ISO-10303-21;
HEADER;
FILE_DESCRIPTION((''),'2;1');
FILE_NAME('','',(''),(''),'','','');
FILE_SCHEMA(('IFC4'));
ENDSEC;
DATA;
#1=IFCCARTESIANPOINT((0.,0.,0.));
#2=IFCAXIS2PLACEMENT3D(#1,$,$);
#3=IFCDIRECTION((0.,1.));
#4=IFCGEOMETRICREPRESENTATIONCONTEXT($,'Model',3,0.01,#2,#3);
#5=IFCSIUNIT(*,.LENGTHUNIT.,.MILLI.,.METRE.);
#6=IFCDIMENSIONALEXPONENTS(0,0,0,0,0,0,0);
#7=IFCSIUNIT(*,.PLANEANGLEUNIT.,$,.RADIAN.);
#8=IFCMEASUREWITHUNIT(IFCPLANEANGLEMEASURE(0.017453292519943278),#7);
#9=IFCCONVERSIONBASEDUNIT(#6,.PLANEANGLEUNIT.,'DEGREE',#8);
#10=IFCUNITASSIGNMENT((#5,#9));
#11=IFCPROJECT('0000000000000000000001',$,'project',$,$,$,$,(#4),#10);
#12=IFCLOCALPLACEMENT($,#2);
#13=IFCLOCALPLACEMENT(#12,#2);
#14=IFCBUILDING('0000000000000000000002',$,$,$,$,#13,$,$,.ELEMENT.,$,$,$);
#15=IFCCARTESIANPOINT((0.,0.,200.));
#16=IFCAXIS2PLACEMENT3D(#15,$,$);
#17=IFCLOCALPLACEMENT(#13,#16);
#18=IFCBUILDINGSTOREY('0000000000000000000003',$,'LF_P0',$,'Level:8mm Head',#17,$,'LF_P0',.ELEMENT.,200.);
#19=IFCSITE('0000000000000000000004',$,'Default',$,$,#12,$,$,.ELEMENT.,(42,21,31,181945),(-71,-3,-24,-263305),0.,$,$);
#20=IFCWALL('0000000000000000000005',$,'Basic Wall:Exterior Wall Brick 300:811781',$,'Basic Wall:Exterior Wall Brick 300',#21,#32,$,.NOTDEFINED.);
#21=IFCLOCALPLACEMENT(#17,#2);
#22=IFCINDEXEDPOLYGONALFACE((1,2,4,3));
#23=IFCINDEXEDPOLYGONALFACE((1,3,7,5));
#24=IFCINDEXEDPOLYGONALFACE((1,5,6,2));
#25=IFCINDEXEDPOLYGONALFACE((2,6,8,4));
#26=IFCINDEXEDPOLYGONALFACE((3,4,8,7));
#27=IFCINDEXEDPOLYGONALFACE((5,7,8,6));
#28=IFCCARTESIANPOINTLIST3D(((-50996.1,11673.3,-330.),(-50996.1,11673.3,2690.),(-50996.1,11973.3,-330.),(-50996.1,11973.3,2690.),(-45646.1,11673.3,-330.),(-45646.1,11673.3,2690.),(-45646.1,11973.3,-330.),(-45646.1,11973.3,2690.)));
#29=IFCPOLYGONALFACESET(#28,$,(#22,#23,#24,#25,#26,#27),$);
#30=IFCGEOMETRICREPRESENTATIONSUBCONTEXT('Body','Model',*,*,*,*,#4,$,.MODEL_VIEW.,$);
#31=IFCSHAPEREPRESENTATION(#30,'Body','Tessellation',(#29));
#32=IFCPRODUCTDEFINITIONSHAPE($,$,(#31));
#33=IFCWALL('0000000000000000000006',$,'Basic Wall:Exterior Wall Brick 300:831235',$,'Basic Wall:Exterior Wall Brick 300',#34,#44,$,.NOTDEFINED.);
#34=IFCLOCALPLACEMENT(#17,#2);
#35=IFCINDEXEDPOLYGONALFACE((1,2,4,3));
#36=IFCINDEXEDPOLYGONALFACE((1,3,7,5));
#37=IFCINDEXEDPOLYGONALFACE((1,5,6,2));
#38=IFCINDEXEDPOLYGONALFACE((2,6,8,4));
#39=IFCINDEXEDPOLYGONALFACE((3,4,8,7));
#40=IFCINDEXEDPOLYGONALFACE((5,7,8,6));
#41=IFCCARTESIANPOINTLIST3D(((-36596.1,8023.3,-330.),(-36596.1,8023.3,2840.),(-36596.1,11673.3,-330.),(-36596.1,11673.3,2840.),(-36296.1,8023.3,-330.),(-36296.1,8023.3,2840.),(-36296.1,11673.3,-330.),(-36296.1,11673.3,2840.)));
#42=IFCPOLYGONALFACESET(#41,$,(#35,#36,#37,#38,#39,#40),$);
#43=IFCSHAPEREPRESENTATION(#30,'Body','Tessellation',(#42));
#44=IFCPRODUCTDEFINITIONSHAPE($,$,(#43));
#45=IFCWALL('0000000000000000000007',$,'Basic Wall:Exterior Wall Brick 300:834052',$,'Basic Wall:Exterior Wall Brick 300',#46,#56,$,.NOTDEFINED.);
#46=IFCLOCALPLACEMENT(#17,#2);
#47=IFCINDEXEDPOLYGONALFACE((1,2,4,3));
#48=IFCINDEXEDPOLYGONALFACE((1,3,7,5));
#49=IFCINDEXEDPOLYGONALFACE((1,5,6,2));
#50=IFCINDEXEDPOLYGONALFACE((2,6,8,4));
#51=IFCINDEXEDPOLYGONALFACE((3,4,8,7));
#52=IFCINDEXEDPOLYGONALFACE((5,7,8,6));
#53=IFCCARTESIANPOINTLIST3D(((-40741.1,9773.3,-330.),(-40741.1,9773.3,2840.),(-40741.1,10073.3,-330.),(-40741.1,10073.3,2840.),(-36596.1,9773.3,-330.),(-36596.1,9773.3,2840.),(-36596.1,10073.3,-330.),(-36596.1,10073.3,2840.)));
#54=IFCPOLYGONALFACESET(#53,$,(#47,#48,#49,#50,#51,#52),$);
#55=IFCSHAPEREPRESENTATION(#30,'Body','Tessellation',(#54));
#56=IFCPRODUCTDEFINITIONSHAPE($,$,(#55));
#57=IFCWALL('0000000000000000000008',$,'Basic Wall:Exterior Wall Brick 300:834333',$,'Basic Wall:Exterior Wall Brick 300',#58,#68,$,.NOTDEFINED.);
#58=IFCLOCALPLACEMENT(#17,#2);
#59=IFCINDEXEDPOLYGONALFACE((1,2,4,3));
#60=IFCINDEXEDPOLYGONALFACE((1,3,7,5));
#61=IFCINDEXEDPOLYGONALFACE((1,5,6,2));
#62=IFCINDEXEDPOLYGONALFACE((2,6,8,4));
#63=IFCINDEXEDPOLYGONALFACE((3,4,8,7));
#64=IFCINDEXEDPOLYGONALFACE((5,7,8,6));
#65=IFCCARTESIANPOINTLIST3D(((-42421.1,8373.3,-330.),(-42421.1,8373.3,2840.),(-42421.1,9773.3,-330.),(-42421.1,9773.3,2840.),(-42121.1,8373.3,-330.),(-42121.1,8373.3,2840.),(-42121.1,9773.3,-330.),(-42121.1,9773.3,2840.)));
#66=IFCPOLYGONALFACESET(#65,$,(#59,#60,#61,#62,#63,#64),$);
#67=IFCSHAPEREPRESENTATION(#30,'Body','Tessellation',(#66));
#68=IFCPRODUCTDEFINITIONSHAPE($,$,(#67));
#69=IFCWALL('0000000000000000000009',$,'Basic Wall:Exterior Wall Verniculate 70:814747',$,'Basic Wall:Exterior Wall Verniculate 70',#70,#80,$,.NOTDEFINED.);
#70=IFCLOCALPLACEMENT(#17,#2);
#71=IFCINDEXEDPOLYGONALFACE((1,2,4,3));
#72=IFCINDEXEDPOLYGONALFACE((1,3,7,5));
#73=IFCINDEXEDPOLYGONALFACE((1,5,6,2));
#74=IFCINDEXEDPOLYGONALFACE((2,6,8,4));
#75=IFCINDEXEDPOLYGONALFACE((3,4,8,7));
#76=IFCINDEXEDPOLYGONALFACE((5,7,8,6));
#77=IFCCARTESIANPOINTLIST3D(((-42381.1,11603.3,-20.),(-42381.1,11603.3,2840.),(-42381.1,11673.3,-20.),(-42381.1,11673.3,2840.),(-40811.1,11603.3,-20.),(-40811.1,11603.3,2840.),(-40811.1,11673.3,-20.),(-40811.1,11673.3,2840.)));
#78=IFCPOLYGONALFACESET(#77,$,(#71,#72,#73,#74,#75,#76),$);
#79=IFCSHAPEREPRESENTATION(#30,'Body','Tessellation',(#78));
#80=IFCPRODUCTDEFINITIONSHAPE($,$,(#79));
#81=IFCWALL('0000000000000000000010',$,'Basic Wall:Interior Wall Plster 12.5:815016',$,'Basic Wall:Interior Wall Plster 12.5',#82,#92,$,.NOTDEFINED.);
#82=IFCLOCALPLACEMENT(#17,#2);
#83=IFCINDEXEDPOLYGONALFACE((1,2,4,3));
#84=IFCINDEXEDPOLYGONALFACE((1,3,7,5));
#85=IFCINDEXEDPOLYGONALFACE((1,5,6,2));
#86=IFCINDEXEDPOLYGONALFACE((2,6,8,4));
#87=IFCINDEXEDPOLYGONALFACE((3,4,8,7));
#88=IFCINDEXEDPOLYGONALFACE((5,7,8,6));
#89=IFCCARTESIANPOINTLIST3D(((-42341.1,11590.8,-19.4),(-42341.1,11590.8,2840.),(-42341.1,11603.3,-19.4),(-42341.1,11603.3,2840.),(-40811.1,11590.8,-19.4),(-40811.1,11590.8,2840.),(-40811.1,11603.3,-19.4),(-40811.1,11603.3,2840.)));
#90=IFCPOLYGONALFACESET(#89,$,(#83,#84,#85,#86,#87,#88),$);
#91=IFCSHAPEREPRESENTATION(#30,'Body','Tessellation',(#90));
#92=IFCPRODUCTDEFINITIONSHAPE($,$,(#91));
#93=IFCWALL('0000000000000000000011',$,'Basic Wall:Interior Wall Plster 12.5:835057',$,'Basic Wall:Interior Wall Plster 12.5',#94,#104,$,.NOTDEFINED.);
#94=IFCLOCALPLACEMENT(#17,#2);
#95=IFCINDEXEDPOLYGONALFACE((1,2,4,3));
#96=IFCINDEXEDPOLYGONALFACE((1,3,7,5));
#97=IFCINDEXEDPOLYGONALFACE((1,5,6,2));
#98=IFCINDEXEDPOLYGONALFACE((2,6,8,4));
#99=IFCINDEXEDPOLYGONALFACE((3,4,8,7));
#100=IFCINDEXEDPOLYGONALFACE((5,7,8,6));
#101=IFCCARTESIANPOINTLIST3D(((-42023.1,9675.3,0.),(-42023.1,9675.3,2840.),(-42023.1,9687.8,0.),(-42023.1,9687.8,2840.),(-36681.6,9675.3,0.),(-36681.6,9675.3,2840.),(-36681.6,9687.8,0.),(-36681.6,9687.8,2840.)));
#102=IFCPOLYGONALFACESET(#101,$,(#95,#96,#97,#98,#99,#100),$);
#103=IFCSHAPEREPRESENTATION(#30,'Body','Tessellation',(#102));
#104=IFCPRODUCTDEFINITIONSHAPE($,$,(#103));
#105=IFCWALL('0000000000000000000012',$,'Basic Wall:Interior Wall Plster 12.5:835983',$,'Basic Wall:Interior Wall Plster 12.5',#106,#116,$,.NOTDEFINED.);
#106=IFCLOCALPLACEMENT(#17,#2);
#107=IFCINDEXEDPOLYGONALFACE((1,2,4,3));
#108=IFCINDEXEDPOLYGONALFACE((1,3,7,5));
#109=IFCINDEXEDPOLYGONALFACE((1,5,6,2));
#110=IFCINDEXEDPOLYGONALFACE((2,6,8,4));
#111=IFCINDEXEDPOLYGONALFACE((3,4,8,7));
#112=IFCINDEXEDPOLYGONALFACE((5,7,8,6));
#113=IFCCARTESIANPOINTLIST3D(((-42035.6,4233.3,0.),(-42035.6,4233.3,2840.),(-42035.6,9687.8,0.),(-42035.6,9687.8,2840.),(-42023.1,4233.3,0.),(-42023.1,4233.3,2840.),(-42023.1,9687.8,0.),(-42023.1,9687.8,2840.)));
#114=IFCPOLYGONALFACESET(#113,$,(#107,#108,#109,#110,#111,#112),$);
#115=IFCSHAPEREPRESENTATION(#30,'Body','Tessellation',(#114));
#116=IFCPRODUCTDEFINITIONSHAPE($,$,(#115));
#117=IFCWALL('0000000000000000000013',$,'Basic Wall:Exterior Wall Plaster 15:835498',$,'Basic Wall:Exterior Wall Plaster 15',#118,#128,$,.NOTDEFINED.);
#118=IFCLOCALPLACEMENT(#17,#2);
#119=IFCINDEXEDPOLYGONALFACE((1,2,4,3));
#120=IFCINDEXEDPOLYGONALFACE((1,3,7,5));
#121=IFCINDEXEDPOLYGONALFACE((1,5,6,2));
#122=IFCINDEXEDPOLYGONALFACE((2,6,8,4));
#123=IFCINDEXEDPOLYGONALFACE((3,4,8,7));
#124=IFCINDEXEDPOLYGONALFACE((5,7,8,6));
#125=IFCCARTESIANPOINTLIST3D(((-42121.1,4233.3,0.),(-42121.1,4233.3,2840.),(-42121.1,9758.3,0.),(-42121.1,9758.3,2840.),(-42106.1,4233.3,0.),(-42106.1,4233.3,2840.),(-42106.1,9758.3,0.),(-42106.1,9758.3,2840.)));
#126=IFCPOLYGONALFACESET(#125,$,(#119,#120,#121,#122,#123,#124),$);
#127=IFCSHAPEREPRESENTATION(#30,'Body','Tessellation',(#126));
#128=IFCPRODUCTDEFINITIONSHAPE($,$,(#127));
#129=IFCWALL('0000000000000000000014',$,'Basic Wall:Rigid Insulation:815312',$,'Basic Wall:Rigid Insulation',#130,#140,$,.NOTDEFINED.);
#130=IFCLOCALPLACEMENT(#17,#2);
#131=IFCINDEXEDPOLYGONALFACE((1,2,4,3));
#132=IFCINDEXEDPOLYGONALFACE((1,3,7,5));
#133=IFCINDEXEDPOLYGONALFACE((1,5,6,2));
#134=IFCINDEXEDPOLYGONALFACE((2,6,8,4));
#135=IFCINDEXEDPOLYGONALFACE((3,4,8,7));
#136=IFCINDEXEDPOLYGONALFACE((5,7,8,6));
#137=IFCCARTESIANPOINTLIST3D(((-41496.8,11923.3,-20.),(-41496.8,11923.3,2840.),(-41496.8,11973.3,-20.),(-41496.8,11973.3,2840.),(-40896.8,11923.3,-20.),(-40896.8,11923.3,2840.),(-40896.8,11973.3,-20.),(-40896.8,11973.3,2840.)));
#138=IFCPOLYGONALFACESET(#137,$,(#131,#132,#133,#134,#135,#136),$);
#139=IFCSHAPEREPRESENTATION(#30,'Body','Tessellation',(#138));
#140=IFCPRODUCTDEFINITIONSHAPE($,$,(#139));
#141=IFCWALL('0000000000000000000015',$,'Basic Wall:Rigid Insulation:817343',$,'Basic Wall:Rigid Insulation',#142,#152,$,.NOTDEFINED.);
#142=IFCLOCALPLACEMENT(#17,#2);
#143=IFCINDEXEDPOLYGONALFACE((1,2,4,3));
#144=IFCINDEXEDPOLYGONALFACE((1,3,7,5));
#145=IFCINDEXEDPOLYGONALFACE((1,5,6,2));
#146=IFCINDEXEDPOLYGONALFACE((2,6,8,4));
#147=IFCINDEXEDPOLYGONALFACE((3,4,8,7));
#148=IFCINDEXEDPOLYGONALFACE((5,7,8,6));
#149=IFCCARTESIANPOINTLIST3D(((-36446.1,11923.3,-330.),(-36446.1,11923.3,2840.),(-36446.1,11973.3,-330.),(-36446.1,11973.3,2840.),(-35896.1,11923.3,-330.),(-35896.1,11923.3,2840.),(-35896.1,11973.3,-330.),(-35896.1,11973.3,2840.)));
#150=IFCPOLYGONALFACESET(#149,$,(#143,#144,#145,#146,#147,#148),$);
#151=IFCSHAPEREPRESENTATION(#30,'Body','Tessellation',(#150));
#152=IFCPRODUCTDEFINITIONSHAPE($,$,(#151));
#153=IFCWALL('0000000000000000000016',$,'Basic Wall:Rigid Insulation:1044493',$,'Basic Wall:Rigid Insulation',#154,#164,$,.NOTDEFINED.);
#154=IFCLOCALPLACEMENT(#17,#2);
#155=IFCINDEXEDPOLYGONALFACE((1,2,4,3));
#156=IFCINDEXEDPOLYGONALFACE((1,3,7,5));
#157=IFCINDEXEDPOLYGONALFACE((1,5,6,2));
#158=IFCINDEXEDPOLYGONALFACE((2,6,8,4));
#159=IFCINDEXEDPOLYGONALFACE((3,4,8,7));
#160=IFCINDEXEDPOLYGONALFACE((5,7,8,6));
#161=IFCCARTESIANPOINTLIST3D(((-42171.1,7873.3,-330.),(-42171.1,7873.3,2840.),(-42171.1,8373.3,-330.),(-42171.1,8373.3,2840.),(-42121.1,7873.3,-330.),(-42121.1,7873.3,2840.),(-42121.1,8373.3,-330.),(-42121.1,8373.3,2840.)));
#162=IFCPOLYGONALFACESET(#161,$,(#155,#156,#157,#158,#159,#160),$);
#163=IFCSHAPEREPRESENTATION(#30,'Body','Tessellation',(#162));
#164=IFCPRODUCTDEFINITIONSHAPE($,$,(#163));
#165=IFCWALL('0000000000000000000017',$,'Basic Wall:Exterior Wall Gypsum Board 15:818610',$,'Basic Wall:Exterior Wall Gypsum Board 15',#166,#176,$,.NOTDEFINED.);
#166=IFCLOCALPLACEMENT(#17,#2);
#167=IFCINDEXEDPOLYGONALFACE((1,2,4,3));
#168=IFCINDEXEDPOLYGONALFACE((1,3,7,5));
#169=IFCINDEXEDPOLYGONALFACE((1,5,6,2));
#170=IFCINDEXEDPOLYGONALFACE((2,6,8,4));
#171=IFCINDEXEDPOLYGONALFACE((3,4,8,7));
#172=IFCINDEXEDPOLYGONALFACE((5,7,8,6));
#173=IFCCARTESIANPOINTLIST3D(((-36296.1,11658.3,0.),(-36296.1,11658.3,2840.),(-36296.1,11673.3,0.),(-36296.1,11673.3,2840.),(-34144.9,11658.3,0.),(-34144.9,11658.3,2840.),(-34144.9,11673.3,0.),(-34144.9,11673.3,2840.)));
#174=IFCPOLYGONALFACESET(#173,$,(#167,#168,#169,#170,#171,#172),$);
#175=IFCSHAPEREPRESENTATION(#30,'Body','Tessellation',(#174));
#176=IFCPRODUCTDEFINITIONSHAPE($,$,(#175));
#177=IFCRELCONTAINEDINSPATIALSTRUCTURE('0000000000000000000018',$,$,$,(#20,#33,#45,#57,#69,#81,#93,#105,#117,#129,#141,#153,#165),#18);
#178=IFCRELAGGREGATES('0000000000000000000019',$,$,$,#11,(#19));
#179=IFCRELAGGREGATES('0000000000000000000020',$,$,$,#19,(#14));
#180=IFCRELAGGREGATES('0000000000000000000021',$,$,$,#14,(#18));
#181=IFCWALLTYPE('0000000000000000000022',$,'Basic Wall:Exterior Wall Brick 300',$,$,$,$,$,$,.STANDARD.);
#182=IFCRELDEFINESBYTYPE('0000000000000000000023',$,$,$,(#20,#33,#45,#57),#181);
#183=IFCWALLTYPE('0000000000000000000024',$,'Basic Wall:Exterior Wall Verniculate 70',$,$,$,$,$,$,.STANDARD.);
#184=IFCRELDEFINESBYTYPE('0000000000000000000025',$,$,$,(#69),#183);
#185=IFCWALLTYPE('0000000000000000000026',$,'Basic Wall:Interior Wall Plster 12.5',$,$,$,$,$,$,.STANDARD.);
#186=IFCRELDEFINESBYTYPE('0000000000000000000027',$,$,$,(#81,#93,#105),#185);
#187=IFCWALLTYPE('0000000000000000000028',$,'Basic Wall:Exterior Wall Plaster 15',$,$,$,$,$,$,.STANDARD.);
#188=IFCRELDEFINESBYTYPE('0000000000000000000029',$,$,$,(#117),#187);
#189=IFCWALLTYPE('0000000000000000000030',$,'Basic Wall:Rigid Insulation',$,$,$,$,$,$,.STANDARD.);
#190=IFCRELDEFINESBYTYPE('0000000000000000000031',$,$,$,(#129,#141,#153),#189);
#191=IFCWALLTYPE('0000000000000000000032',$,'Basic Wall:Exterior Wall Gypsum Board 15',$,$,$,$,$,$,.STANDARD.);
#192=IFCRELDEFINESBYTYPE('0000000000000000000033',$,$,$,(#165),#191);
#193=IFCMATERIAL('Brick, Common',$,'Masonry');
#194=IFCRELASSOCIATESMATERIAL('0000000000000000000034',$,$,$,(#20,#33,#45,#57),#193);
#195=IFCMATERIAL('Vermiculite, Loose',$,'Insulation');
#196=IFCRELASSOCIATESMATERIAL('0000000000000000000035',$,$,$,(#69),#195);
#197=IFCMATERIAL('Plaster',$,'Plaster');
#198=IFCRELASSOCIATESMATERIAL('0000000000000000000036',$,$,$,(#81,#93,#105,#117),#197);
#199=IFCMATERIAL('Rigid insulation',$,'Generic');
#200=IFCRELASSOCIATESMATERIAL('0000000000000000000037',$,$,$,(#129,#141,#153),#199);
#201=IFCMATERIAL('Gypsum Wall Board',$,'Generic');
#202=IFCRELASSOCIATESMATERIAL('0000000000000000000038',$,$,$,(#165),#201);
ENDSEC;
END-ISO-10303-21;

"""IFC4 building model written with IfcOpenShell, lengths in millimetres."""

from ifc_helpers import new_model, entity, si_unit, converted_unit, direction, frame, origin, place, context, subcontext, project, spatial, indexed_curve, outline, extrude, material, type_object, element, save


model = new_model("IFC4")

# Units and contexts
model_context = context("Model", 3, precision=0.01, world=origin(), true_north=direction((0.0, 1.0)))
body_context = subcontext(model_context, "Body", "Model", "MODEL_VIEW")
ifc_project = project(units=[si_unit("LENGTHUNIT", "METRE", prefix="MILLI"), converted_unit("PLANEANGLEUNIT", "DEGREE", entity("IfcPlaneAngleMeasure", 0.017453292519943278), si_unit("PLANEANGLEUNIT", "RADIAN"), dimensions=[0, 0, 0, 0, 0, 0, 0])], contexts=[model_context])

# Site, building, storey
site_placement = place(None, origin())
site = spatial("IfcSite", under=ifc_project, at=site_placement, Name="Default", CompositionType="ELEMENT", RefLatitude=(42, 21, 31, 181945), RefLongitude=(-71, -3, -24, -263305), RefElevation=0.0)
building_placement = place(site_placement, origin())
building = spatial("IfcBuilding", under=site, at=building_placement, CompositionType="ELEMENT")
storey_placement = place(building_placement, frame((0.0, 0.0, 200.0)))
storey = spatial("IfcBuildingStorey", under=building, at=storey_placement, Name="LF_P0", ObjectType="Level:8mm Head", LongName="LF_P0", CompositionType="ELEMENT", Elevation=200.0)

# Walls
ifc_material_1 = material(Name="Brick, Common", Category="Masonry")
wall_type_1 = type_object("IfcWallType", Name="Basic Wall:Exterior Wall Brick 300", PredefinedType="STANDARD")
wall_1_placement = place(storey_placement, frame((-45646.1, 11823.3, -330.0), z_axis=(0.0, 0.0, 1.0), x_axis=(-1.0, 0.0, 0.0)))
element("IfcWall", 1, at=wall_1_placement, inside=storey, type_object=wall_type_1, material=ifc_material_1, Name="Basic Wall:Exterior Wall Brick 300:811781", ObjectType="Basic Wall:Exterior Wall Brick 300", PredefinedType="NOTDEFINED", context=body_context, shape_type="SweptSolid", body=[
    extrude(outline(indexed_curve([(5350.0, 150.0), (0.0, 150.0), (0.0, -150.0), (5350.0, -150.0), (5350.0, 150.0)], self_intersect=False)), origin(), (0.0, 0.0, 1.0), 3020.0),
])
wall_2_placement = place(storey_placement, frame((-36446.1, 8023.3, -330.0), z_axis=(0.0, 0.0, 1.0), x_axis=(0.0, 1.0, 0.0)))
element("IfcWall", 2, at=wall_2_placement, inside=storey, type_object=wall_type_1, material=ifc_material_1, Name="Basic Wall:Exterior Wall Brick 300:831235", ObjectType="Basic Wall:Exterior Wall Brick 300", PredefinedType="NOTDEFINED", context=body_context, shape_type="SweptSolid", body=[
    extrude(outline(indexed_curve([(3650.0, 150.0), (0.0, 150.0), (0.0, -150.0), (3650.0, -150.0), (3650.0, 150.0)], self_intersect=False)), origin(), (0.0, 0.0, 1.0), 3170.0),
])
wall_3_placement = place(storey_placement, frame((-36596.1, 9923.3, -330.0), z_axis=(0.0, 0.0, 1.0), x_axis=(-1.0, 0.0, 0.0)))
element("IfcWall", 3, at=wall_3_placement, inside=storey, type_object=wall_type_1, material=ifc_material_1, Name="Basic Wall:Exterior Wall Brick 300:834052", ObjectType="Basic Wall:Exterior Wall Brick 300", PredefinedType="NOTDEFINED", context=body_context, shape_type="SweptSolid", body=[
    extrude(outline(indexed_curve([(4145.0, 150.0), (0.0, 150.0), (0.0, -150.0), (4145.0, -150.0), (4145.0, 150.0)], self_intersect=False)), origin(), (0.0, 0.0, 1.0), 3170.0),
])
wall_4_placement = place(storey_placement, frame((-42271.1, 9773.3, -330.0), z_axis=(0.0, 0.0, 1.0), x_axis=(0.0, -1.0, 0.0)))
element("IfcWall", 4, at=wall_4_placement, inside=storey, type_object=wall_type_1, material=ifc_material_1, Name="Basic Wall:Exterior Wall Brick 300:834333", ObjectType="Basic Wall:Exterior Wall Brick 300", PredefinedType="NOTDEFINED", context=body_context, shape_type="SweptSolid", body=[
    extrude(outline(indexed_curve([(1400.0, 150.0), (0.0, 150.0), (0.0, -150.0), (1400.0, -150.0), (1400.0, 150.0)], self_intersect=False)), origin(), (0.0, 0.0, 1.0), 3170.0),
])
ifc_material_2 = material(Name="Vermiculite, Loose", Category="Insulation")
wall_type_2 = type_object("IfcWallType", Name="Basic Wall:Exterior Wall Verniculate 70", PredefinedType="STANDARD")
wall_5_placement = place(storey_placement, frame((-42381.1, 11638.3, -20.0)))
element("IfcWall", 5, at=wall_5_placement, inside=storey, type_object=wall_type_2, material=ifc_material_2, Name="Basic Wall:Exterior Wall Verniculate 70:814747", ObjectType="Basic Wall:Exterior Wall Verniculate 70", PredefinedType="NOTDEFINED", context=body_context, shape_type="SweptSolid", body=[
    extrude(outline(indexed_curve([(1570.0, 35.0), (0.0, 35.0), (0.0, -35.0), (1570.0, -35.0), (1570.0, 35.0)], self_intersect=False)), origin(), (0.0, 0.0, 1.0), 2860.0),
])
ifc_material_3 = material(Name="Plaster", Category="Plaster")
wall_type_3 = type_object("IfcWallType", Name="Basic Wall:Interior Wall Plster 12.5", PredefinedType="STANDARD")
wall_6_placement = place(storey_placement, frame((-42341.1, 11597.1, -19.4)))
element("IfcWall", 6, at=wall_6_placement, inside=storey, type_object=wall_type_3, material=ifc_material_3, Name="Basic Wall:Interior Wall Plster 12.5:815016", ObjectType="Basic Wall:Interior Wall Plster 12.5", PredefinedType="NOTDEFINED", context=body_context, shape_type="SweptSolid", body=[
    extrude(outline(indexed_curve([(1530.0, 6.3), (0.0, 6.3), (0.0, -6.3), (1530.0, -6.3), (1530.0, 6.3)], self_intersect=False)), origin(), (0.0, 0.0, 1.0), 2859.4),
])
wall_7_placement = place(storey_placement, frame((-36681.6, 9681.6, 0.0), z_axis=(0.0, 0.0, 1.0), x_axis=(-1.0, 0.0, 0.0)))
element("IfcWall", 7, at=wall_7_placement, inside=storey, type_object=wall_type_3, material=ifc_material_3, Name="Basic Wall:Interior Wall Plster 12.5:835057", ObjectType="Basic Wall:Interior Wall Plster 12.5", PredefinedType="NOTDEFINED", context=body_context, shape_type="SweptSolid", body=[
    extrude(outline(indexed_curve([(5341.5, 6.2), (0.0, 6.2), (0.0, -6.2), (5341.5, -6.2), (5341.5, 6.2)], self_intersect=False)), origin(), (0.0, 0.0, 1.0), 2840.0),
])
wall_8_placement = place(storey_placement, frame((-42029.4, 9687.8, 0.0), z_axis=(0.0, 0.0, 1.0), x_axis=(0.0, -1.0, 0.0)))
element("IfcWall", 8, at=wall_8_placement, inside=storey, type_object=wall_type_3, material=ifc_material_3, Name="Basic Wall:Interior Wall Plster 12.5:835983", ObjectType="Basic Wall:Interior Wall Plster 12.5", PredefinedType="NOTDEFINED", context=body_context, shape_type="SweptSolid", body=[
    extrude(outline(indexed_curve([(5454.5, 6.3), (0.0, 6.3), (0.0, -6.3), (5454.5, -6.3), (5454.5, 6.3)], self_intersect=False)), origin(), (0.0, 0.0, 1.0), 2840.0),
])
wall_type_4 = type_object("IfcWallType", Name="Basic Wall:Exterior Wall Plaster 15", PredefinedType="STANDARD")
wall_9_placement = place(storey_placement, frame((-42113.6, 9758.3, 0.0), z_axis=(0.0, 0.0, 1.0), x_axis=(0.0, -1.0, 0.0)))
element("IfcWall", 9, at=wall_9_placement, inside=storey, type_object=wall_type_4, material=ifc_material_3, Name="Basic Wall:Exterior Wall Plaster 15:835498", ObjectType="Basic Wall:Exterior Wall Plaster 15", PredefinedType="NOTDEFINED", context=body_context, shape_type="SweptSolid", body=[
    extrude(outline(indexed_curve([(5525.0, 7.5), (0.0, 7.5), (0.0, -7.5), (5525.0, -7.5), (5525.0, 7.5)], self_intersect=False)), origin(), (0.0, 0.0, 1.0), 2840.0),
])
ifc_material_4 = material(Name="Rigid insulation", Category="Generic")
wall_type_5 = type_object("IfcWallType", Name="Basic Wall:Rigid Insulation", PredefinedType="STANDARD")
wall_10_placement = place(storey_placement, frame((-41496.8, 11948.3, -20.0)))
element("IfcWall", 10, at=wall_10_placement, inside=storey, type_object=wall_type_5, material=ifc_material_4, Name="Basic Wall:Rigid Insulation:815312", ObjectType="Basic Wall:Rigid Insulation", PredefinedType="NOTDEFINED", context=body_context, shape_type="SweptSolid", body=[
    extrude(outline(indexed_curve([(600.0, 25.0), (0.0, 25.0), (0.0, -25.0), (600.0, -25.0), (600.0, 25.0)], self_intersect=False)), origin(), (0.0, 0.0, 1.0), 2860.0),
])
wall_11_placement = place(storey_placement, frame((-36446.1, 11948.3, -330.0)))
element("IfcWall", 11, at=wall_11_placement, inside=storey, type_object=wall_type_5, material=ifc_material_4, Name="Basic Wall:Rigid Insulation:817343", ObjectType="Basic Wall:Rigid Insulation", PredefinedType="NOTDEFINED", context=body_context, shape_type="SweptSolid", body=[
    extrude(outline(indexed_curve([(550.0, 25.0), (0.0, 25.0), (0.0, -25.0), (550.0, -25.0), (550.0, 25.0)], self_intersect=False)), origin(), (0.0, 0.0, 1.0), 3170.0),
])
wall_12_placement = place(storey_placement, frame((-42146.1, 8373.3, -330.0), z_axis=(0.0, 0.0, 1.0), x_axis=(0.0, -1.0, 0.0)))
element("IfcWall", 12, at=wall_12_placement, inside=storey, type_object=wall_type_5, material=ifc_material_4, Name="Basic Wall:Rigid Insulation:1044493", ObjectType="Basic Wall:Rigid Insulation", PredefinedType="NOTDEFINED", context=body_context, shape_type="SweptSolid", body=[
    extrude(outline(indexed_curve([(500.0, 25.0), (0.0, 25.0), (0.0, -25.0), (500.0, -25.0), (500.0, 25.0)], self_intersect=False)), origin(), (0.0, 0.0, 1.0), 3170.0),
])
ifc_material_5 = material(Name="Gypsum Wall Board", Category="Generic")
wall_type_6 = type_object("IfcWallType", Name="Basic Wall:Exterior Wall Gypsum Board 15", PredefinedType="STANDARD")
wall_13_placement = place(storey_placement, frame((-36296.1, 11665.8, 0.0)))
element("IfcWall", 13, at=wall_13_placement, inside=storey, type_object=wall_type_6, material=ifc_material_5, Name="Basic Wall:Exterior Wall Gypsum Board 15:818610", ObjectType="Basic Wall:Exterior Wall Gypsum Board 15", PredefinedType="NOTDEFINED", context=body_context, shape_type="SweptSolid", body=[
    extrude(outline(indexed_curve([(2151.2, 7.5), (0.0, 7.5), (0.0, -7.5), (2151.2, -7.5), (2151.2, 7.5)], self_intersect=False)), origin(), (0.0, 0.0, 1.0), 2840.0),
])

save(model, "model.ifc")
